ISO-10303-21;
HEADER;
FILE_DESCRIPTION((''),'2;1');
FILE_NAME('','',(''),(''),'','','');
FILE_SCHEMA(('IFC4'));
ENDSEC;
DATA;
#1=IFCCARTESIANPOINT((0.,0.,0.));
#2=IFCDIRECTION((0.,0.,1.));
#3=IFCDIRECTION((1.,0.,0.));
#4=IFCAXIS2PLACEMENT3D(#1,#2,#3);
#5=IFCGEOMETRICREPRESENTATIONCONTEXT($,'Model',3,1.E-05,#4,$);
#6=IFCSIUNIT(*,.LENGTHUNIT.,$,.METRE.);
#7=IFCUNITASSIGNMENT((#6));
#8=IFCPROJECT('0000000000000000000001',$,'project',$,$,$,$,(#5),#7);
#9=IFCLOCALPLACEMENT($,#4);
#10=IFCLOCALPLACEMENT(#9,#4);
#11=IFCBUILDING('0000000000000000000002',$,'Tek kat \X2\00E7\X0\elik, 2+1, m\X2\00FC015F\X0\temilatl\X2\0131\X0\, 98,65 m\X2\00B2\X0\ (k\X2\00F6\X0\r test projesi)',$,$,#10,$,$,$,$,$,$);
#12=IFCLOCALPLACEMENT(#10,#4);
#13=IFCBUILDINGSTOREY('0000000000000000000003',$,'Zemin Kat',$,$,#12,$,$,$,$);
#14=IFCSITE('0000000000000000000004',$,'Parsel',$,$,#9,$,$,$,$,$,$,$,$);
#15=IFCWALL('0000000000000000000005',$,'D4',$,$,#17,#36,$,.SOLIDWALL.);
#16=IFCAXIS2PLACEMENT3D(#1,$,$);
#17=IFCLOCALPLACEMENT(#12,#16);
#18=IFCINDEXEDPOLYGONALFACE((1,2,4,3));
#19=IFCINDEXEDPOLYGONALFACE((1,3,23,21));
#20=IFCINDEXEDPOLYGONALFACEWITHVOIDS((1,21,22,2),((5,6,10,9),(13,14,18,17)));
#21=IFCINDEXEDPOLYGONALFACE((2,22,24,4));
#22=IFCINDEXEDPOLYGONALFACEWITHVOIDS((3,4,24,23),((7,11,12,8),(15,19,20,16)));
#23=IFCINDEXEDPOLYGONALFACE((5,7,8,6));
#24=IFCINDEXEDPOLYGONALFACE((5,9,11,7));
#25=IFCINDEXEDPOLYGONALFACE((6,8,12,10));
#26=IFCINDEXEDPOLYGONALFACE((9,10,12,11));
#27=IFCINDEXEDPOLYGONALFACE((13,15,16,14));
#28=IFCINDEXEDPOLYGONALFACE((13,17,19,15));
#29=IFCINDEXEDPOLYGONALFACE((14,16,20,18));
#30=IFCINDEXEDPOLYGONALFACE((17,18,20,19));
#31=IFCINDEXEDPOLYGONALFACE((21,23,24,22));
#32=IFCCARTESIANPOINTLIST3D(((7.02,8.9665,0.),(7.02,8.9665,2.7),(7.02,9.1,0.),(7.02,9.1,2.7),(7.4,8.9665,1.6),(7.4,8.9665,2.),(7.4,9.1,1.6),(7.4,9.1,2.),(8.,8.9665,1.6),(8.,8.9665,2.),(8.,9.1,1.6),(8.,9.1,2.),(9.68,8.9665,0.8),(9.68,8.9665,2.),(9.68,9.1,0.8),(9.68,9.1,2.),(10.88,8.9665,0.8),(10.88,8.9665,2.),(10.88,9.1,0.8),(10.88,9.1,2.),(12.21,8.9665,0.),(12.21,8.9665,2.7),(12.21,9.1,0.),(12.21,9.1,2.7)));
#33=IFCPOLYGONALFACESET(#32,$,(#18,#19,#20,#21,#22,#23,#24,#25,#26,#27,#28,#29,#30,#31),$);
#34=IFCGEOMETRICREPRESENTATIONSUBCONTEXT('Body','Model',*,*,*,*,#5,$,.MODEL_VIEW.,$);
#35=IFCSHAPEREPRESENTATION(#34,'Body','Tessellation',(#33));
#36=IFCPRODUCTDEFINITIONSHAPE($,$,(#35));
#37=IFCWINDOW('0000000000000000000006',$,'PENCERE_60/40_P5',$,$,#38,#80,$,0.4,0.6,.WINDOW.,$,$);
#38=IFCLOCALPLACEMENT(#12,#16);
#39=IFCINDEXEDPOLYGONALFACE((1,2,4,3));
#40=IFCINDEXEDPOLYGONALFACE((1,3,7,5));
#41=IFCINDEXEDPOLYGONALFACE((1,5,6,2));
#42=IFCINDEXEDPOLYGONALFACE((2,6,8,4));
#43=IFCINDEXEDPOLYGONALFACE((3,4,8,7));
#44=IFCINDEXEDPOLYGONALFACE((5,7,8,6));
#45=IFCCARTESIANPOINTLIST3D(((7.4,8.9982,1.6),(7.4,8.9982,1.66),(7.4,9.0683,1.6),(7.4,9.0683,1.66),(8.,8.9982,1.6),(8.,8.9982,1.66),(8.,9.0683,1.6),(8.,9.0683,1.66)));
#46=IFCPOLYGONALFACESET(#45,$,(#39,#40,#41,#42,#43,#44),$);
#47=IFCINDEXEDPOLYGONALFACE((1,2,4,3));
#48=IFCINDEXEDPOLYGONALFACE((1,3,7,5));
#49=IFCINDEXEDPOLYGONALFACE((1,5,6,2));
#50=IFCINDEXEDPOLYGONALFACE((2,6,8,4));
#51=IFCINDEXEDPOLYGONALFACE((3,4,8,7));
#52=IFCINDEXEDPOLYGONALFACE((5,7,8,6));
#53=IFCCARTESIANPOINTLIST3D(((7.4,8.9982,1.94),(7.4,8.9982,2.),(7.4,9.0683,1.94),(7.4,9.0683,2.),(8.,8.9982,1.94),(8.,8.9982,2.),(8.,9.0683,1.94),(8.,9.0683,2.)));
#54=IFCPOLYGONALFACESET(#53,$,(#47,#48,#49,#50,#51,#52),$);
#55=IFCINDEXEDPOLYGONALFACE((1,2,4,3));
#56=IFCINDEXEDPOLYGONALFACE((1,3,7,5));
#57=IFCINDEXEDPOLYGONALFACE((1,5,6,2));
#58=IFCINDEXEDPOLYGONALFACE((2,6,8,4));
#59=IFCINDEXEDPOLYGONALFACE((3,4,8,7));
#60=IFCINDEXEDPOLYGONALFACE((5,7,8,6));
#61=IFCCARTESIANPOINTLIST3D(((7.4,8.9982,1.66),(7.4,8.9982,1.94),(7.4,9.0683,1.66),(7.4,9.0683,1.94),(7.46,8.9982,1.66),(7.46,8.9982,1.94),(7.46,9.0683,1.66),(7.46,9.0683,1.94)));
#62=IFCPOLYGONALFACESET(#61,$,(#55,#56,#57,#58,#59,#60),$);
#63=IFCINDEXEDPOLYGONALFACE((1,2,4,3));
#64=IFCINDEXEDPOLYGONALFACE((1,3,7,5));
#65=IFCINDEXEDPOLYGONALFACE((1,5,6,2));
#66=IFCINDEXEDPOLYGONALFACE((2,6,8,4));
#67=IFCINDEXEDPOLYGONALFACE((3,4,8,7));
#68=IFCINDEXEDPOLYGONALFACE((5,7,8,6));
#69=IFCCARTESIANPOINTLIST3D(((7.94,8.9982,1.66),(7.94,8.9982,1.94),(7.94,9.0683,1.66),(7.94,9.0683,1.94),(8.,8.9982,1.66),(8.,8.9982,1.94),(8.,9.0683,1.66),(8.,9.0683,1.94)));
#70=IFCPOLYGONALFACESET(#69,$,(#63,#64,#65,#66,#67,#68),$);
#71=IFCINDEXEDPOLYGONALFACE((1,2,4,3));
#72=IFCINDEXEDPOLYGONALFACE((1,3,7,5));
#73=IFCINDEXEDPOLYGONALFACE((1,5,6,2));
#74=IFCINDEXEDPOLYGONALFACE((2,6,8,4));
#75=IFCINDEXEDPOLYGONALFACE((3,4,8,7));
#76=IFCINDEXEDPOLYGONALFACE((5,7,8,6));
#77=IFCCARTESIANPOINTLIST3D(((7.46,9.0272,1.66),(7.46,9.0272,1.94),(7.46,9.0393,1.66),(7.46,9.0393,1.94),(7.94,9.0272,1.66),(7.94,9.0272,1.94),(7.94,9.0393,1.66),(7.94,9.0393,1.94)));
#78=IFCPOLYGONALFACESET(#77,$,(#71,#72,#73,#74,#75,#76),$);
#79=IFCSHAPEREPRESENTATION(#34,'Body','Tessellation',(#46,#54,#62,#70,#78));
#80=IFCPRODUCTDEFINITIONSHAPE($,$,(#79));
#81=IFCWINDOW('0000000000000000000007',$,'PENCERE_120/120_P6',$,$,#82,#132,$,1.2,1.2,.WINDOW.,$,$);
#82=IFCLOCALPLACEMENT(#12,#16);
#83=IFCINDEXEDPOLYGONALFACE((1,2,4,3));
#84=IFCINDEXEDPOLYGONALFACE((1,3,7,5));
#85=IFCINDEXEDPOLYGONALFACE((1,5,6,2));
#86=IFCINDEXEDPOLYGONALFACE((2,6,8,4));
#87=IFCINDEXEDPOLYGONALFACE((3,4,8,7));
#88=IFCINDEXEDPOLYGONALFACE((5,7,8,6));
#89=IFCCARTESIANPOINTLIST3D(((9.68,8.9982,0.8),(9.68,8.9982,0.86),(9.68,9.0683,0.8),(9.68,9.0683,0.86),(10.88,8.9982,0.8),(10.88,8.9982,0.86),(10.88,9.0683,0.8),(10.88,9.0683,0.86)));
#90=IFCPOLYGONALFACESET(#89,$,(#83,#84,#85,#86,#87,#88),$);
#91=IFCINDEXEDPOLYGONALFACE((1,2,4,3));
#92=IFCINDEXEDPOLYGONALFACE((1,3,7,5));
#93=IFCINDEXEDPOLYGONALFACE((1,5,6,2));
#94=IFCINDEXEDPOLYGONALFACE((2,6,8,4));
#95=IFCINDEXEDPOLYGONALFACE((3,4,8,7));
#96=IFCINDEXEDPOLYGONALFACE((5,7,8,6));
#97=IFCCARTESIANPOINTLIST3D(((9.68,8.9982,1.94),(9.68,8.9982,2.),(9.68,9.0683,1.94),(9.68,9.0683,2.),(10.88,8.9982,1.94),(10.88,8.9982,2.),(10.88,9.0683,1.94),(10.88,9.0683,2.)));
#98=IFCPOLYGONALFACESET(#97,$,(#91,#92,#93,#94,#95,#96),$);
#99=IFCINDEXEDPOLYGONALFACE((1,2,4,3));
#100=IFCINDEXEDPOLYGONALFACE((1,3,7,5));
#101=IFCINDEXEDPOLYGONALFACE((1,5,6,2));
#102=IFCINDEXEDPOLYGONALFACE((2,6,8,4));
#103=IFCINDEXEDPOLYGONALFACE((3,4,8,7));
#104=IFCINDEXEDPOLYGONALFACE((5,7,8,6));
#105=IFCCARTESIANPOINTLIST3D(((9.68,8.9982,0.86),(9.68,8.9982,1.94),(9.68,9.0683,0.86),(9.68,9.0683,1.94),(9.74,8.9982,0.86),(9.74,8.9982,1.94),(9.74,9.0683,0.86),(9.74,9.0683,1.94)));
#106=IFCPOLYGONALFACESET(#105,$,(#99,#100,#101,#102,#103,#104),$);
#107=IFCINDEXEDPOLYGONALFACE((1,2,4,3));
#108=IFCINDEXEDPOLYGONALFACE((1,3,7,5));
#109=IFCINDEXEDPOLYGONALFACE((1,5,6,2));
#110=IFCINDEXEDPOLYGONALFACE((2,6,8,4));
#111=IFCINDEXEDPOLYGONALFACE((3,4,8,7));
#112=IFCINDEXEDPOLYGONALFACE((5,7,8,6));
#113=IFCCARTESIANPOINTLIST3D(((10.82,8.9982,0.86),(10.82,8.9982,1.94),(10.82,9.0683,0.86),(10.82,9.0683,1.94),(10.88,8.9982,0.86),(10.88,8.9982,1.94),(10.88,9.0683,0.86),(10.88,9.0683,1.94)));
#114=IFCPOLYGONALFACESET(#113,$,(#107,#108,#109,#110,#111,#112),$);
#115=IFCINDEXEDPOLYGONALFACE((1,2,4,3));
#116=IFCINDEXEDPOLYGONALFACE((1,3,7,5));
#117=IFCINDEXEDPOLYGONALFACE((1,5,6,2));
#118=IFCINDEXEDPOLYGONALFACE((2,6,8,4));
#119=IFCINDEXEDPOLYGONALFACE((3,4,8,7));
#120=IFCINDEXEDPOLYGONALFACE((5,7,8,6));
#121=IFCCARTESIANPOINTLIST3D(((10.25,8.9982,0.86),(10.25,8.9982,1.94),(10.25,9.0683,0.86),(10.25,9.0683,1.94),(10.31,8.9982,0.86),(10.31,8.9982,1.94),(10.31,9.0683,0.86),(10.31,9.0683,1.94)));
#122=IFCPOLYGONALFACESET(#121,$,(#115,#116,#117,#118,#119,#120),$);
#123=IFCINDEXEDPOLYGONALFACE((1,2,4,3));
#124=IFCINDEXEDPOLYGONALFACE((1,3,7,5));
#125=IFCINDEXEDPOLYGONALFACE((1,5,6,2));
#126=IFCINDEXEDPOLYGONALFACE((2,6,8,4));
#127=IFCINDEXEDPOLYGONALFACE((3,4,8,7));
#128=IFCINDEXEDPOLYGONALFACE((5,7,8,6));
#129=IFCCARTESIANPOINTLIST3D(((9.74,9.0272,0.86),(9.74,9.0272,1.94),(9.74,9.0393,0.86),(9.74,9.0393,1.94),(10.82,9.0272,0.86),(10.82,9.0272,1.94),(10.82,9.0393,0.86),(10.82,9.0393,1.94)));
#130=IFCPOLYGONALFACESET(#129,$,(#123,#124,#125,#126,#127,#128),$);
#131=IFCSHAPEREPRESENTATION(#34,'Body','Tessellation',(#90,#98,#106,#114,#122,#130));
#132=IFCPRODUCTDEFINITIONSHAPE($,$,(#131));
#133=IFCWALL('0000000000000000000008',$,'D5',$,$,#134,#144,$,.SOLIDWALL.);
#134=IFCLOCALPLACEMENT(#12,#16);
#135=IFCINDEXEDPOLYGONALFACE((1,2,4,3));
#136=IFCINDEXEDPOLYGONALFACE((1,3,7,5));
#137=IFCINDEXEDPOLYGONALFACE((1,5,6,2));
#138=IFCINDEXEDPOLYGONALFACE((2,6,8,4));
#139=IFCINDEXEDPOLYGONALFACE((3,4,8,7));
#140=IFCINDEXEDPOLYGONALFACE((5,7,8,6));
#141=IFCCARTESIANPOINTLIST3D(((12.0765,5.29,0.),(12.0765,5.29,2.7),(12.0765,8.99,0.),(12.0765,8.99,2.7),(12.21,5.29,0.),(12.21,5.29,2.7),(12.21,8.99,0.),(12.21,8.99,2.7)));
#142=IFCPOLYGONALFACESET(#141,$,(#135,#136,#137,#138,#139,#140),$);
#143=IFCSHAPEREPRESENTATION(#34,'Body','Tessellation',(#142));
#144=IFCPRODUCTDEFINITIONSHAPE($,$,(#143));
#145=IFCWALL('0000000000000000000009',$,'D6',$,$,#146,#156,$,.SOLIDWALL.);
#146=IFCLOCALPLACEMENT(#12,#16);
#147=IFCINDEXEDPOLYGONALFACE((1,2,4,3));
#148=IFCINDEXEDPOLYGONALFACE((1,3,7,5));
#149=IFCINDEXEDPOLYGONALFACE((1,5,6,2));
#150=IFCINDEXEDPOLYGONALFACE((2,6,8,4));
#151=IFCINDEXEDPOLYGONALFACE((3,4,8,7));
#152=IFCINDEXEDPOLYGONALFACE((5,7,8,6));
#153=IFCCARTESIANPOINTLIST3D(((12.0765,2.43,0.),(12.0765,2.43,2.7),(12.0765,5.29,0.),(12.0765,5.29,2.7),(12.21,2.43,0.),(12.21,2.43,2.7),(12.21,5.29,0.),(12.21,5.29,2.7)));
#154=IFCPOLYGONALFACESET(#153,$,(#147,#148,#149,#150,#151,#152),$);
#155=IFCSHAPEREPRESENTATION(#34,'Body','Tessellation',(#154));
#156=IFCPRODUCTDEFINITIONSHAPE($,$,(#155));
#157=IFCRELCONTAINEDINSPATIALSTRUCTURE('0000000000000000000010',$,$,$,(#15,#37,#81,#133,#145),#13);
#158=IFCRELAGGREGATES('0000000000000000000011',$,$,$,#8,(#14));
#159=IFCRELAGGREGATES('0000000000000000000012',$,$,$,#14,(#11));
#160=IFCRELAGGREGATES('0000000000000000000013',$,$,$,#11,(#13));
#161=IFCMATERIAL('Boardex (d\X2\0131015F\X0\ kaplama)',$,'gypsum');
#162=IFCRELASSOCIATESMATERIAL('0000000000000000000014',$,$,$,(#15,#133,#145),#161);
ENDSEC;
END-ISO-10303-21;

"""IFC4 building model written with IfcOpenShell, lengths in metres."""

from ifc_helpers import new_model, si_unit, frame, origin_with_axes, place, context, subcontext, project, spatial, line, indexed_curve, outline, extrude, material, element, fill, save


model = new_model("IFC4")

# Units and contexts
model_context = context("Model", 3, precision=1e-05, world=origin_with_axes())
body_context = subcontext(model_context, "Body", "Model", "MODEL_VIEW")
ifc_project = project(units=[si_unit("LENGTHUNIT", "METRE")], contexts=[model_context])

# Site, building, storey
site_placement = place(None, origin_with_axes())
site = spatial("IfcSite", under=ifc_project, at=site_placement, Name="Parsel")
building_placement = place(site_placement, origin_with_axes())
building = spatial("IfcBuilding", under=site, at=building_placement, Name="Tek kat çelik, 2+1, müştemilatlı, 98,65 m² (kör test projesi)")
storey_placement = place(building_placement, origin_with_axes())
storey = spatial("IfcBuildingStorey", under=building, at=storey_placement, Name="Zemin Kat")

# Shared definitions
ifc_material_1 = material(Name="Boardex (dış kaplama)", Category="gypsum")

# Wall, openings, windows
wall_1_placement = place(storey_placement, origin_with_axes())
wall_1 = element("IfcWall", 1, at=wall_1_placement, inside=storey, material=ifc_material_1, Name="D4", PredefinedType="SOLIDWALL", context=body_context, shape_type="SweptSolid", body=[
    extrude(outline(indexed_curve([(0.0, 0.0), (5.19, 0.0), (5.19, 0.1335), (0.0, 0.1335)], segments=[line(1, 2, 3, 4, 1)])), frame((7.02, 8.9665, 0.0), z_axis=(0.0, 0.0, 1.0), x_axis=(1.0, 0.0, 0.0)), (0.0, 0.0, 1.0), 2.7),
])
opening_1_placement = place(wall_1_placement, origin_with_axes())
opening_1 = element("IfcOpeningElement", 2, at=opening_1_placement, cuts=wall_1, PredefinedType="OPENING", context=body_context, shape_type="SweptSolid", body=[
    extrude(outline(indexed_curve([(0.0, 0.0), (0.6, 0.0), (0.6, 0.1735), (0.0, 0.1735)], segments=[line(1, 2, 3, 4, 1)])), frame((7.4, 8.9465, 1.6), z_axis=(0.0, 0.0, 1.0), x_axis=(1.0, 0.0, 0.0)), (0.0, 0.0, 1.0), 0.4),
])
opening_2_placement = place(wall_1_placement, origin_with_axes())
opening_2 = element("IfcOpeningElement", 3, at=opening_2_placement, cuts=wall_1, PredefinedType="OPENING", context=body_context, shape_type="SweptSolid", body=[
    extrude(outline(indexed_curve([(0.0, 0.0), (1.2, 0.0), (1.2, 0.1735), (0.0, 0.1735)], segments=[line(1, 2, 3, 4, 1)])), frame((9.68, 8.9465, 0.8), z_axis=(0.0, 0.0, 1.0), x_axis=(1.0, 0.0, 0.0)), (0.0, 0.0, 1.0), 1.2),
])
window_1_placement = place(storey_placement, origin_with_axes())
window_1 = element("IfcWindow", 4, at=window_1_placement, inside=storey, Name="PENCERE_60/40_P5", OverallHeight=0.4, OverallWidth=0.6, PredefinedType="WINDOW", context=body_context, shape_type="SweptSolid", body=[
    extrude(outline(indexed_curve([(0.0, 0.0), (0.6, 0.0), (0.6, 0.07), (0.0, 0.07)], segments=[line(1, 2, 3, 4, 1)])), frame((7.4, 8.9983, 1.6), z_axis=(0.0, 0.0, 1.0), x_axis=(1.0, 0.0, 0.0)), (0.0, 0.0, 1.0), 0.06),
    extrude(outline(indexed_curve([(0.0, 0.0), (0.6, 0.0), (0.6, 0.07), (0.0, 0.07)], segments=[line(1, 2, 3, 4, 1)])), frame((7.4, 8.9983, 1.94), z_axis=(0.0, 0.0, 1.0), x_axis=(1.0, 0.0, 0.0)), (0.0, 0.0, 1.0), 0.06),
    extrude(outline(indexed_curve([(0.0, 0.0), (0.06, 0.0), (0.06, 0.07), (0.0, 0.07)], segments=[line(1, 2, 3, 4, 1)])), frame((7.4, 8.9983, 1.66), z_axis=(0.0, 0.0, 1.0), x_axis=(1.0, 0.0, 0.0)), (0.0, 0.0, 1.0), 0.28),
    extrude(outline(indexed_curve([(0.0, 0.0), (0.06, 0.0), (0.06, 0.07), (0.0, 0.07)], segments=[line(1, 2, 3, 4, 1)])), frame((7.94, 8.9983, 1.66), z_axis=(0.0, 0.0, 1.0), x_axis=(1.0, 0.0, 0.0)), (0.0, 0.0, 1.0), 0.28),
    extrude(outline(indexed_curve([(0.0, 0.0), (0.48, 0.0), (0.48, 0.012), (0.0, 0.012)], segments=[line(1, 2, 3, 4, 1)])), frame((7.46, 9.0273, 1.66), z_axis=(0.0, 0.0, 1.0), x_axis=(1.0, 0.0, 0.0)), (0.0, 0.0, 1.0), 0.28),
])
fill(opening_1, window_1)
window_2_placement = place(storey_placement, origin_with_axes())
window_2 = element("IfcWindow", 5, at=window_2_placement, inside=storey, Name="PENCERE_120/120_P6", OverallHeight=1.2, OverallWidth=1.2, PredefinedType="WINDOW", context=body_context, shape_type="SweptSolid", body=[
    extrude(outline(indexed_curve([(0.0, 0.0), (1.2, 0.0), (1.2, 0.07), (0.0, 0.07)], segments=[line(1, 2, 3, 4, 1)])), frame((9.68, 8.9983, 0.8), z_axis=(0.0, 0.0, 1.0), x_axis=(1.0, 0.0, 0.0)), (0.0, 0.0, 1.0), 0.06),
    extrude(outline(indexed_curve([(0.0, 0.0), (1.2, 0.0), (1.2, 0.07), (0.0, 0.07)], segments=[line(1, 2, 3, 4, 1)])), frame((9.68, 8.9983, 1.94), z_axis=(0.0, 0.0, 1.0), x_axis=(1.0, 0.0, 0.0)), (0.0, 0.0, 1.0), 0.06),
    extrude(outline(indexed_curve([(0.0, 0.0), (0.06, 0.0), (0.06, 0.07), (0.0, 0.07)], segments=[line(1, 2, 3, 4, 1)])), frame((9.68, 8.9983, 0.86), z_axis=(0.0, 0.0, 1.0), x_axis=(1.0, 0.0, 0.0)), (0.0, 0.0, 1.0), 1.08),
    extrude(outline(indexed_curve([(0.0, 0.0), (0.06, 0.0), (0.06, 0.07), (0.0, 0.07)], segments=[line(1, 2, 3, 4, 1)])), frame((10.82, 8.9983, 0.86), z_axis=(0.0, 0.0, 1.0), x_axis=(1.0, 0.0, 0.0)), (0.0, 0.0, 1.0), 1.08),
    extrude(outline(indexed_curve([(0.0, 0.0), (0.06, 0.0), (0.06, 0.07), (0.0, 0.07)], segments=[line(1, 2, 3, 4, 1)])), frame((10.25, 8.9983, 0.86), z_axis=(0.0, 0.0, 1.0), x_axis=(1.0, 0.0, 0.0)), (0.0, 0.0, 1.0), 1.08),
    extrude(outline(indexed_curve([(0.0, 0.0), (1.08, 0.0), (1.08, 0.012), (0.0, 0.012)], segments=[line(1, 2, 3, 4, 1)])), frame((9.74, 9.0273, 0.86), z_axis=(0.0, 0.0, 1.0), x_axis=(1.0, 0.0, 0.0)), (0.0, 0.0, 1.0), 1.08),
])
fill(opening_2, window_2)

# Walls
wall_2_placement = place(storey_placement, origin_with_axes())
element("IfcWall", 6, at=wall_2_placement, inside=storey, material=ifc_material_1, Name="D5", PredefinedType="SOLIDWALL", context=body_context, shape_type="SweptSolid", body=[
    extrude(outline(indexed_curve([(0.0, 0.0), (0.1335, 0.0), (0.1335, 3.7), (0.0, 3.7)], segments=[line(1, 2, 3, 4, 1)])), frame((12.0765, 5.29, 0.0), z_axis=(0.0, 0.0, 1.0), x_axis=(1.0, 0.0, 0.0)), (0.0, 0.0, 1.0), 2.7),
])
wall_3_placement = place(storey_placement, origin_with_axes())
element("IfcWall", 7, at=wall_3_placement, inside=storey, material=ifc_material_1, Name="D6", PredefinedType="SOLIDWALL", context=body_context, shape_type="SweptSolid", body=[
    extrude(outline(indexed_curve([(0.0, 0.0), (0.1335, 0.0), (0.1335, 2.86), (0.0, 2.86)], segments=[line(1, 2, 3, 4, 1)])), frame((12.0765, 2.43, 0.0), z_axis=(0.0, 0.0, 1.0), x_axis=(1.0, 0.0, 0.0)), (0.0, 0.0, 1.0), 2.7),
])

save(model, "model.ifc")
